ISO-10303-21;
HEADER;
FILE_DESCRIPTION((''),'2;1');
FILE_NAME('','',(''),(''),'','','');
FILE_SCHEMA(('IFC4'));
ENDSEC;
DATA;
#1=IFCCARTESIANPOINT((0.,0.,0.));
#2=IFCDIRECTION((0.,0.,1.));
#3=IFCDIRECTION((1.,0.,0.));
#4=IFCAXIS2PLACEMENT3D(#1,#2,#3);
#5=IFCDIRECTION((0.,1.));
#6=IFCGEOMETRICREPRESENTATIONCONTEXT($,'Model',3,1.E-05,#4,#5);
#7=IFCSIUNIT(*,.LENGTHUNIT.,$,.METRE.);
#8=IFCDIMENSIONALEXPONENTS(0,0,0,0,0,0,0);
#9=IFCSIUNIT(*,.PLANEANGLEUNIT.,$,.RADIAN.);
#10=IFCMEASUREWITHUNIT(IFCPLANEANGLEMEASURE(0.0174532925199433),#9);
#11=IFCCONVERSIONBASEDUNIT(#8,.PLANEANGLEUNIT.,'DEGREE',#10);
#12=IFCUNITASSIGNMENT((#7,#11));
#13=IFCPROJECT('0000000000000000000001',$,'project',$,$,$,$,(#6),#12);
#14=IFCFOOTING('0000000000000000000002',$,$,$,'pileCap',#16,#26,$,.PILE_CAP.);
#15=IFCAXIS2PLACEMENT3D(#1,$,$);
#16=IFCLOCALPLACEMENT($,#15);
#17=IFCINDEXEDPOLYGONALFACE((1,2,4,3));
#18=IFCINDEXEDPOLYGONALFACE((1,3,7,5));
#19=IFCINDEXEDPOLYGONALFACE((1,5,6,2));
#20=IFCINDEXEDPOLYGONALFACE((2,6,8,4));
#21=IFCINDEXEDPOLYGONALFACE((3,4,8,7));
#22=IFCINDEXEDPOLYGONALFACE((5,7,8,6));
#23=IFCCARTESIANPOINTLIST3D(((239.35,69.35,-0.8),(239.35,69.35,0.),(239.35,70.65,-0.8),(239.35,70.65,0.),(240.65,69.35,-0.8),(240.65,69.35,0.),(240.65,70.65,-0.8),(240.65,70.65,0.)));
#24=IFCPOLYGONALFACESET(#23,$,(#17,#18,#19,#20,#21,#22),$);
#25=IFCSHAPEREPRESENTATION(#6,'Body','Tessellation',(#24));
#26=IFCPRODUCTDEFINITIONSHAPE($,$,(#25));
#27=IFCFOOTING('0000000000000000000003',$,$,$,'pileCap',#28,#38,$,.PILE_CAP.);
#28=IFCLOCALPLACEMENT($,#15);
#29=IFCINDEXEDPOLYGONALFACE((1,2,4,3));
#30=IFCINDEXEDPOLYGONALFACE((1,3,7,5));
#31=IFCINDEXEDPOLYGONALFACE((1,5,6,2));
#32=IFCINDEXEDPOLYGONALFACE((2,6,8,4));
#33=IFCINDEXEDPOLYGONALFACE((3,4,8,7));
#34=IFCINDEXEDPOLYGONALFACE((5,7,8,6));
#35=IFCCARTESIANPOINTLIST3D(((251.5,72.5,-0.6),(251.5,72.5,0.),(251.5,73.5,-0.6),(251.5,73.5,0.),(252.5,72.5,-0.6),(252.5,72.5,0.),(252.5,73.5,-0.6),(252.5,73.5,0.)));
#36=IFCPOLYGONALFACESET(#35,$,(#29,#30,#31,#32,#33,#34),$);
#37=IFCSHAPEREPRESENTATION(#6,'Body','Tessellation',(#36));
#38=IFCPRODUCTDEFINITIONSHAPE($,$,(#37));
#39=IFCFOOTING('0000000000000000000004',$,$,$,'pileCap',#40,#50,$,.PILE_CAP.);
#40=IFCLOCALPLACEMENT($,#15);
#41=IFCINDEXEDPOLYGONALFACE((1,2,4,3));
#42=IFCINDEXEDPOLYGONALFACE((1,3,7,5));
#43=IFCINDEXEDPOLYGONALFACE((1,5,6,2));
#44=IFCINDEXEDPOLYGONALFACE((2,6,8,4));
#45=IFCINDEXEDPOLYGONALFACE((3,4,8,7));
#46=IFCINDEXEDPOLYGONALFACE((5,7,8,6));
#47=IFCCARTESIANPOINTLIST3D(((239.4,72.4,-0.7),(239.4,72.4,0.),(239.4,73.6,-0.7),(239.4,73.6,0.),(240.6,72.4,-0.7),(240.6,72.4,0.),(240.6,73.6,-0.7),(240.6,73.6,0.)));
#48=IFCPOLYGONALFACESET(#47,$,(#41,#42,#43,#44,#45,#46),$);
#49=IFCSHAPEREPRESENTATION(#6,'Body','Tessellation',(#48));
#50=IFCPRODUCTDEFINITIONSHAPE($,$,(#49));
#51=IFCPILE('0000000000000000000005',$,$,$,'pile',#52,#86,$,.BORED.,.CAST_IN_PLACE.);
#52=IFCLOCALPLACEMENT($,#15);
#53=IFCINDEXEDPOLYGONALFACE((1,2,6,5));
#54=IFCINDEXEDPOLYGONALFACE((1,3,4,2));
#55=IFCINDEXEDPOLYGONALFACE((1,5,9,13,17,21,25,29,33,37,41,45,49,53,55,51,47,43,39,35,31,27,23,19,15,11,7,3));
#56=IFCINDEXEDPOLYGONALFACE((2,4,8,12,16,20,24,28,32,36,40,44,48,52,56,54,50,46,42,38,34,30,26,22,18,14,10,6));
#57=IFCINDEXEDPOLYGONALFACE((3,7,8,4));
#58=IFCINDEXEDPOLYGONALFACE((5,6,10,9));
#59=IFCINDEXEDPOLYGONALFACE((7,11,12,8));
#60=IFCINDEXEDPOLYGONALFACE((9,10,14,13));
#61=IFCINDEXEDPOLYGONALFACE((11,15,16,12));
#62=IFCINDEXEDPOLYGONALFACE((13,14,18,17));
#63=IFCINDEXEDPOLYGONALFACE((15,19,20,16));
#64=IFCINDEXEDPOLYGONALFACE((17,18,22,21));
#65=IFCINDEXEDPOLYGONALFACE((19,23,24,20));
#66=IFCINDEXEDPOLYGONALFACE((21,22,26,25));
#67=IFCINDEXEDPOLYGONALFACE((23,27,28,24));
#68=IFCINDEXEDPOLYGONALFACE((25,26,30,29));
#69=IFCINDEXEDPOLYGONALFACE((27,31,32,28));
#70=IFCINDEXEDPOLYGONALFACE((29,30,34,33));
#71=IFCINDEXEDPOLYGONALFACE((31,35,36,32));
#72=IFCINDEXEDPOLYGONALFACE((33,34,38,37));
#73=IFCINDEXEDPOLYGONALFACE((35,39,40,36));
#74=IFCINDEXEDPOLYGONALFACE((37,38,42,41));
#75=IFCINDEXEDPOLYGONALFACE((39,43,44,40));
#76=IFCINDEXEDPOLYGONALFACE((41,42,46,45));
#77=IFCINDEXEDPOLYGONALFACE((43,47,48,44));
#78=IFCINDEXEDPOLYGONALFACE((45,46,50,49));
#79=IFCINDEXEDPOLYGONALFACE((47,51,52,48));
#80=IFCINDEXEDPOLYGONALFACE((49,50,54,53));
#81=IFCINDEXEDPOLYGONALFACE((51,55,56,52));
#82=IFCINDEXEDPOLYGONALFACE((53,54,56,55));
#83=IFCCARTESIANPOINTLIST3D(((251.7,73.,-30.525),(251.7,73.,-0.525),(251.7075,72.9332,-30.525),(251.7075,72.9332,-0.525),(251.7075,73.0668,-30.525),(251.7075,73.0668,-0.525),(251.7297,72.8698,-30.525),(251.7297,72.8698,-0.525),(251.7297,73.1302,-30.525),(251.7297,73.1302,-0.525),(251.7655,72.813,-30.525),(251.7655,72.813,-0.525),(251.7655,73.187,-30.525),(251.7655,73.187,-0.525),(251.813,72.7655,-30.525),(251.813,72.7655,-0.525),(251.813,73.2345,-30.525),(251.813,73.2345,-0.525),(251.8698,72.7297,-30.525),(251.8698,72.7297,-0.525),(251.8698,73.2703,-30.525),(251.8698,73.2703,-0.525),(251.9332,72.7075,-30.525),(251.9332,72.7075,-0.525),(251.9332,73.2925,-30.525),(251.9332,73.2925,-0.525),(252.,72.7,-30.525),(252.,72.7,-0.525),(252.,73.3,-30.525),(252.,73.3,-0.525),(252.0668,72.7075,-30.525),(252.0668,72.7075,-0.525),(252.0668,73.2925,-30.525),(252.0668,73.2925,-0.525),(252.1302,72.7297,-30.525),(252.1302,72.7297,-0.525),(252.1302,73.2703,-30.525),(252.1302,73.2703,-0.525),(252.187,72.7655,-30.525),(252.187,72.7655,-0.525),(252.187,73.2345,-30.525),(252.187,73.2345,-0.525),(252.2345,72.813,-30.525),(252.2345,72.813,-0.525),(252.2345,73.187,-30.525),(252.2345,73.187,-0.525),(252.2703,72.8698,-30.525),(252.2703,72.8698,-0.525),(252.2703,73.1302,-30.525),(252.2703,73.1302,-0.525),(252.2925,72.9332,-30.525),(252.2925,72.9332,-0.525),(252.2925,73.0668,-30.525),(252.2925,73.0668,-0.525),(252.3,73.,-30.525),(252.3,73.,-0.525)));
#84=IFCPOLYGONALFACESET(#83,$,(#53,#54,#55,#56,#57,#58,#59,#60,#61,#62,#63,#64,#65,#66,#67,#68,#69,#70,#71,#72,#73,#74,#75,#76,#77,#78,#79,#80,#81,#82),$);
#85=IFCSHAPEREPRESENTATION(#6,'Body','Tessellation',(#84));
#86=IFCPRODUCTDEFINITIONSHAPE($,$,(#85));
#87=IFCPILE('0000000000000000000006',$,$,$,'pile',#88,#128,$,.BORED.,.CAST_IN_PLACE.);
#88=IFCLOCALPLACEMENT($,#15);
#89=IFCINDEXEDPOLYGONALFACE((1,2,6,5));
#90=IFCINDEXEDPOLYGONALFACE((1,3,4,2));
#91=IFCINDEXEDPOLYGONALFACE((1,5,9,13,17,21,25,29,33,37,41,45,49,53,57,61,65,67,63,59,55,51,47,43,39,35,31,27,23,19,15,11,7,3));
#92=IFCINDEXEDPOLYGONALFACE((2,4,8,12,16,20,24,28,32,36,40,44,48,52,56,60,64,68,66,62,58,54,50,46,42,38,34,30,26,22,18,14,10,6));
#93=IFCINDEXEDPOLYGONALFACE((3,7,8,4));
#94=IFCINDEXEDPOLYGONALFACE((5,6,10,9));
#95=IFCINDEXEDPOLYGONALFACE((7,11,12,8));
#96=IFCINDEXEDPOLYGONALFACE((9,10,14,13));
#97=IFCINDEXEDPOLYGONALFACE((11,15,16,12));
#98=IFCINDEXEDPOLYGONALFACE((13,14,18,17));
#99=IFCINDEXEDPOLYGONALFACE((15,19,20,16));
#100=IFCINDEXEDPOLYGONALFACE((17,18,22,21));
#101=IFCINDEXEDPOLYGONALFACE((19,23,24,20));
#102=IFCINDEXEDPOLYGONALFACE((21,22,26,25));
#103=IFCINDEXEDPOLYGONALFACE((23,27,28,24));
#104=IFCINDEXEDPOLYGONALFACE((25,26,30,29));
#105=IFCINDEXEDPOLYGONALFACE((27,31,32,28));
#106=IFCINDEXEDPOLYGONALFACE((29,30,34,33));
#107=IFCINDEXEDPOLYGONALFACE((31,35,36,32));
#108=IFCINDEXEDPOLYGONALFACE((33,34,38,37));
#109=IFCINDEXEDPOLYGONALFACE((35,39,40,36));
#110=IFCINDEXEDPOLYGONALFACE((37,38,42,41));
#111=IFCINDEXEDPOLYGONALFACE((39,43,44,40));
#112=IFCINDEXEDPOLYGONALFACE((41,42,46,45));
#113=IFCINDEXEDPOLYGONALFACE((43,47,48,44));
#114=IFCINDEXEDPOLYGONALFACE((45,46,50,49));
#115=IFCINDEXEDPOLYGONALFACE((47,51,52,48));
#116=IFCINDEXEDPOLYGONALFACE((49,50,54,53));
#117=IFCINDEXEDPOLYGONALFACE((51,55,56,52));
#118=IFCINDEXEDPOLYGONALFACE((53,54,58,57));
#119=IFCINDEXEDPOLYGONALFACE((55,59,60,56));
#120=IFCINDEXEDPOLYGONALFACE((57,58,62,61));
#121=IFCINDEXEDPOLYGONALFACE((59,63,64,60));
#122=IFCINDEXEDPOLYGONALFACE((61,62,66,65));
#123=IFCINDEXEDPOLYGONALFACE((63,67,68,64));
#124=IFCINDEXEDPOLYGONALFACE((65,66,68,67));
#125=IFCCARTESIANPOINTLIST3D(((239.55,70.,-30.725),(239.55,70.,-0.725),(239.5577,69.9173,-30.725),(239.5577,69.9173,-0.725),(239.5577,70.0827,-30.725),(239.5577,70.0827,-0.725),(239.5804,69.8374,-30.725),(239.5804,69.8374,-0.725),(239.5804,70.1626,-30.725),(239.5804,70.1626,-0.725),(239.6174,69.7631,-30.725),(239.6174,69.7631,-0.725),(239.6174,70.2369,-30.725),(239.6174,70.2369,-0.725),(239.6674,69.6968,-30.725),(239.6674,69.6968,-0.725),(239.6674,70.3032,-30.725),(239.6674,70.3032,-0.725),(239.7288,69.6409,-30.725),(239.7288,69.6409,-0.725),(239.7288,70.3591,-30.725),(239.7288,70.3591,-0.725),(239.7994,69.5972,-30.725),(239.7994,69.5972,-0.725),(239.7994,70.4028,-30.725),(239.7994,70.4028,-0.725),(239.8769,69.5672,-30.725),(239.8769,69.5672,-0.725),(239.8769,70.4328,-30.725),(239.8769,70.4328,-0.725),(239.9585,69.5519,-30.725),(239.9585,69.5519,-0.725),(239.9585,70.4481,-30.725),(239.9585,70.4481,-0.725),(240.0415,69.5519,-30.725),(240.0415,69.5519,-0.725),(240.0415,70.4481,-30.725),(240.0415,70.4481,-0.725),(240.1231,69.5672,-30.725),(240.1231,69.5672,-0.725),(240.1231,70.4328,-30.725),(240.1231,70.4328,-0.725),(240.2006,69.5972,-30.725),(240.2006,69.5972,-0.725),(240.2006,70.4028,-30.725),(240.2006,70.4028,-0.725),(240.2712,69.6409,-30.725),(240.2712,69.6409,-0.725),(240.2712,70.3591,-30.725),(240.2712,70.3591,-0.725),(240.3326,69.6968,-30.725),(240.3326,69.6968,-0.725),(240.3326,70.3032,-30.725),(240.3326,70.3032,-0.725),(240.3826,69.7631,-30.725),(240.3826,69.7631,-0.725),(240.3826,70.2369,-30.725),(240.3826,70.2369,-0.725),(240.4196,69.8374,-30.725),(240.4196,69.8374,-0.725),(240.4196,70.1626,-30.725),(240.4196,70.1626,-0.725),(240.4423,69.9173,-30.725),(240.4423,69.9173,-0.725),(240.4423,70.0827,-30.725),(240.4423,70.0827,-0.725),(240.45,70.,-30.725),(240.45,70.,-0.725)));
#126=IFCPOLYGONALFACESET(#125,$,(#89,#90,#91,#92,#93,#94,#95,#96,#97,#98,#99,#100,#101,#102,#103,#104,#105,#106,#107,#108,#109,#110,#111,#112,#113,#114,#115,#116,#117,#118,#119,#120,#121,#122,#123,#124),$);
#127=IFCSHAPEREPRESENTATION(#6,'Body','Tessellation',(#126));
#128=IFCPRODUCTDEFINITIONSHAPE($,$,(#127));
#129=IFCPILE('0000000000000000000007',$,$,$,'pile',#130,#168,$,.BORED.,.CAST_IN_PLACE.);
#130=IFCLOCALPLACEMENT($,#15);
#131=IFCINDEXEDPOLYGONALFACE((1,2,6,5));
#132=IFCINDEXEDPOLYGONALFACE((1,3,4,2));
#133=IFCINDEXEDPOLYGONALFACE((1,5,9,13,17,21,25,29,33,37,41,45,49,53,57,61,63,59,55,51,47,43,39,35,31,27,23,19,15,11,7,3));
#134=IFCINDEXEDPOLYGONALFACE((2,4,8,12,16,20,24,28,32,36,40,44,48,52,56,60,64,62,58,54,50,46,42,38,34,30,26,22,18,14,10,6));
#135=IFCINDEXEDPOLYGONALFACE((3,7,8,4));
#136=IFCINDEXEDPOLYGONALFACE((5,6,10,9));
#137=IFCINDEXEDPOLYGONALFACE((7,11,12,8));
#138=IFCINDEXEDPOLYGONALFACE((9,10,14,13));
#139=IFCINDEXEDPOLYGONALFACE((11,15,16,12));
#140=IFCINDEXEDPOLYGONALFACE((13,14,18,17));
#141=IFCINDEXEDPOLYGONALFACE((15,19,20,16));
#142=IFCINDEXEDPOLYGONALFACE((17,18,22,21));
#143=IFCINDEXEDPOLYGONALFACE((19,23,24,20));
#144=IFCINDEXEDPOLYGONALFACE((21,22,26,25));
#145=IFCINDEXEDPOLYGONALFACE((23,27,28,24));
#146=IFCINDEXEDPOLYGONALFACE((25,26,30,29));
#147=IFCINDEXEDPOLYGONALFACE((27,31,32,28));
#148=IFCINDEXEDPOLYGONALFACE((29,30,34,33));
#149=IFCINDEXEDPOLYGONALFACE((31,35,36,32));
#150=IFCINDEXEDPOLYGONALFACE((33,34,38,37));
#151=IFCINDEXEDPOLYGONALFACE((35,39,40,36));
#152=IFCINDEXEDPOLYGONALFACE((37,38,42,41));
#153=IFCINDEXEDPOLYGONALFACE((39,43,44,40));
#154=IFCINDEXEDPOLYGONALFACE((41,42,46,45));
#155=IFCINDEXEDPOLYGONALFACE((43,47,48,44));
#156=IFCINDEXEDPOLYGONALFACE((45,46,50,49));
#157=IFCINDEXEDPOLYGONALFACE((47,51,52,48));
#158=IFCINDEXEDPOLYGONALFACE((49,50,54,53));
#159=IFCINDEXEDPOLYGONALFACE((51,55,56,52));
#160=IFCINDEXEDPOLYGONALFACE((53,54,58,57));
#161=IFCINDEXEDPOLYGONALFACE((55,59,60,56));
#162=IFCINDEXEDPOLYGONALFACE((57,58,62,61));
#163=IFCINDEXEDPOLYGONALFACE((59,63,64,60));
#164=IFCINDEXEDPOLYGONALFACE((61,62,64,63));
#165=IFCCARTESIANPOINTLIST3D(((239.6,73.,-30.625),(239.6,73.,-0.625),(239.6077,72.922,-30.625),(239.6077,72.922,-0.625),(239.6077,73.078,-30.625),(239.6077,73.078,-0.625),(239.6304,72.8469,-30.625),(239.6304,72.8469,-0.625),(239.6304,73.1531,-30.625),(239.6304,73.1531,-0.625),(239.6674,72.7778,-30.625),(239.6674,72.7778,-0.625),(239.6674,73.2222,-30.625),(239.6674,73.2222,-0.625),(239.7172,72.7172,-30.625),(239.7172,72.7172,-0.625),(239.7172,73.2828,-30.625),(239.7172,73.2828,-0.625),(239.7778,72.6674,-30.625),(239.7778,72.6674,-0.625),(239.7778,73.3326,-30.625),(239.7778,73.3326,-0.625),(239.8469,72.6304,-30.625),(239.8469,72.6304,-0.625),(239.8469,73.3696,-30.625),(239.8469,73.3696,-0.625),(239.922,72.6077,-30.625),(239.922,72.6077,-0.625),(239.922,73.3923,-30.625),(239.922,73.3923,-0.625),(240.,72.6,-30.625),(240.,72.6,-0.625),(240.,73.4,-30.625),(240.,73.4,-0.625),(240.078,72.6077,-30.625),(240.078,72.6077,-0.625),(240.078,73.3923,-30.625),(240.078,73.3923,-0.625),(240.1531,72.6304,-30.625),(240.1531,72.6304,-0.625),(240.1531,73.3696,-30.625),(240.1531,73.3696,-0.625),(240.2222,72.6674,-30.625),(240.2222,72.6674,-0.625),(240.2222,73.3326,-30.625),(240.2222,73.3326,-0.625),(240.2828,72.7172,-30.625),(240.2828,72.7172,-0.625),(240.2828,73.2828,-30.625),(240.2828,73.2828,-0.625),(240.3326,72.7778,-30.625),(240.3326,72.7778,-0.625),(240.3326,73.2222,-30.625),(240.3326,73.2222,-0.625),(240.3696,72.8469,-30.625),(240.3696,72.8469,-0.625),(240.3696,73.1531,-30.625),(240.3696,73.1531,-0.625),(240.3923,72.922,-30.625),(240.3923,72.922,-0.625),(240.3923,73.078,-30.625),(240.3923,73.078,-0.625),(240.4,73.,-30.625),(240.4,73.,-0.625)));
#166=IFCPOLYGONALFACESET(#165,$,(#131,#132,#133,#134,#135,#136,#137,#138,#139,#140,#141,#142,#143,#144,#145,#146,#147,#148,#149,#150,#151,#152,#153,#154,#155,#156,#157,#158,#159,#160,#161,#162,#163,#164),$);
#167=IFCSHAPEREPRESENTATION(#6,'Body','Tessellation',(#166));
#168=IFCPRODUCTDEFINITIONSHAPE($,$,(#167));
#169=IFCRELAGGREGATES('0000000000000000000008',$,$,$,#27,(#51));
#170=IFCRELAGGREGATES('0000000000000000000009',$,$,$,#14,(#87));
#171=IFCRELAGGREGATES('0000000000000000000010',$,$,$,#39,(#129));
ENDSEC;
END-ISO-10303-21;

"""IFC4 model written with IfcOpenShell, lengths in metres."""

from ifc_helpers import new_model, entity, si_unit, converted_unit, direction, frame, origin_with_axes, place, context, project, polyline, circle_curve, parameter, trimmed, segment, composite_curve, outline, extrude, element, aggregate, save


model = new_model("IFC4")

# Units and contexts
model_context = context("Model", 3, precision=1e-05, world=origin_with_axes(), true_north=direction((0.0, 1.0)))
ifc_project = project(units=[si_unit("LENGTHUNIT", "METRE"), converted_unit("PLANEANGLEUNIT", "DEGREE", entity("IfcPlaneAngleMeasure", 0.0174532925199433), si_unit("PLANEANGLEUNIT", "RADIAN"), dimensions=[0, 0, 0, 0, 0, 0, 0])], contexts=[model_context])

# Footings
placement_1 = place(None, origin_with_axes())
placement_2 = place(placement_1, origin_with_axes())
footing_1_placement = place(placement_2, frame((240.0, 70.0, -0.8), z_axis=(0.0, 0.0, 1.0), x_axis=(1.0, 0.0, 0.0)))
footing_1 = element("IfcFooting", 1, at=footing_1_placement, ObjectType="pileCap", PredefinedType="PILE_CAP", context=model_context, body=[
    extrude(outline(polyline([(0.65, -0.65, 0.0), (0.65, 0.65, 0.0), (-0.65, 0.65, 0.0), (-0.65, -0.65, 0.0), (0.65, -0.65, 0.0)])), origin_with_axes(), (0.0, 0.0, 1.0), 0.8),
])
footing_2_placement = place(placement_2, frame((252.0, 73.0, -0.6), z_axis=(0.0, 0.0, 1.0), x_axis=(1.0, 0.0, 0.0)))
footing_2 = element("IfcFooting", 2, at=footing_2_placement, ObjectType="pileCap", PredefinedType="PILE_CAP", context=model_context, body=[
    extrude(outline(polyline([(0.5, -0.5, 0.0), (0.5, 0.5, 0.0), (-0.5, 0.5, 0.0), (-0.5, -0.5, 0.0), (0.5, -0.5, 0.0)])), origin_with_axes(), (0.0, 0.0, 1.0), 0.6),
])
footing_3_placement = place(placement_2, frame((240.0, 73.0, -0.7), z_axis=(0.0, 0.0, 1.0), x_axis=(1.0, 0.0, 0.0)))
footing_3 = element("IfcFooting", 3, at=footing_3_placement, ObjectType="pileCap", PredefinedType="PILE_CAP", context=model_context, body=[
    extrude(outline(polyline([(0.6, -0.6, 0.0), (0.6, 0.6, 0.0), (-0.6, 0.6, 0.0), (-0.6, -0.6, 0.0), (0.6, -0.6, 0.0)])), origin_with_axes(), (0.0, 0.0, 1.0), 0.7),
])

# Piles
pile_1_placement = place(footing_2_placement, frame((0.0, 0.0, -29.925), z_axis=(0.0, 0.0, 1.0), x_axis=(1.0, 0.0, 0.0)))
pile_1 = element("IfcPile", 4, at=pile_1_placement, ObjectType="pile", ConstructionType="CAST_IN_PLACE", PredefinedType="BORED", context=model_context, body=[
    extrude(outline(composite_curve([segment(trimmed(circle_curve(origin_with_axes(), 0.3), [parameter(0.0)], [parameter(360.0)], True, "PARAMETER"), True, "CONTINUOUS")], self_intersect=False)), origin_with_axes(), (0.0, 0.0, 1.0), 30.0),
])
aggregate(footing_2, [pile_1])
pile_2_placement = place(footing_1_placement, frame((0.0, 0.0, -29.925), z_axis=(0.0, 0.0, 1.0), x_axis=(1.0, 0.0, 0.0)))
pile_2 = element("IfcPile", 5, at=pile_2_placement, ObjectType="pile", ConstructionType="CAST_IN_PLACE", PredefinedType="BORED", context=model_context, body=[
    extrude(outline(composite_curve([segment(trimmed(circle_curve(origin_with_axes(), 0.45), [parameter(0.0)], [parameter(360.0)], True, "PARAMETER"), True, "CONTINUOUS")], self_intersect=False)), origin_with_axes(), (0.0, 0.0, 1.0), 30.0),
])
aggregate(footing_1, [pile_2])
pile_3_placement = place(footing_3_placement, frame((0.0, 0.0, -29.925), z_axis=(0.0, 0.0, 1.0), x_axis=(1.0, 0.0, 0.0)))
pile_3 = element("IfcPile", 6, at=pile_3_placement, ObjectType="pile", ConstructionType="CAST_IN_PLACE", PredefinedType="BORED", context=model_context, body=[
    extrude(outline(composite_curve([segment(trimmed(circle_curve(origin_with_axes(), 0.4), [parameter(0.0)], [parameter(360.0)], True, "PARAMETER"), True, "CONTINUOUS")], self_intersect=False)), origin_with_axes(), (0.0, 0.0, 1.0), 30.0),
])
aggregate(footing_3, [pile_3])

save(model, "model.ifc")
